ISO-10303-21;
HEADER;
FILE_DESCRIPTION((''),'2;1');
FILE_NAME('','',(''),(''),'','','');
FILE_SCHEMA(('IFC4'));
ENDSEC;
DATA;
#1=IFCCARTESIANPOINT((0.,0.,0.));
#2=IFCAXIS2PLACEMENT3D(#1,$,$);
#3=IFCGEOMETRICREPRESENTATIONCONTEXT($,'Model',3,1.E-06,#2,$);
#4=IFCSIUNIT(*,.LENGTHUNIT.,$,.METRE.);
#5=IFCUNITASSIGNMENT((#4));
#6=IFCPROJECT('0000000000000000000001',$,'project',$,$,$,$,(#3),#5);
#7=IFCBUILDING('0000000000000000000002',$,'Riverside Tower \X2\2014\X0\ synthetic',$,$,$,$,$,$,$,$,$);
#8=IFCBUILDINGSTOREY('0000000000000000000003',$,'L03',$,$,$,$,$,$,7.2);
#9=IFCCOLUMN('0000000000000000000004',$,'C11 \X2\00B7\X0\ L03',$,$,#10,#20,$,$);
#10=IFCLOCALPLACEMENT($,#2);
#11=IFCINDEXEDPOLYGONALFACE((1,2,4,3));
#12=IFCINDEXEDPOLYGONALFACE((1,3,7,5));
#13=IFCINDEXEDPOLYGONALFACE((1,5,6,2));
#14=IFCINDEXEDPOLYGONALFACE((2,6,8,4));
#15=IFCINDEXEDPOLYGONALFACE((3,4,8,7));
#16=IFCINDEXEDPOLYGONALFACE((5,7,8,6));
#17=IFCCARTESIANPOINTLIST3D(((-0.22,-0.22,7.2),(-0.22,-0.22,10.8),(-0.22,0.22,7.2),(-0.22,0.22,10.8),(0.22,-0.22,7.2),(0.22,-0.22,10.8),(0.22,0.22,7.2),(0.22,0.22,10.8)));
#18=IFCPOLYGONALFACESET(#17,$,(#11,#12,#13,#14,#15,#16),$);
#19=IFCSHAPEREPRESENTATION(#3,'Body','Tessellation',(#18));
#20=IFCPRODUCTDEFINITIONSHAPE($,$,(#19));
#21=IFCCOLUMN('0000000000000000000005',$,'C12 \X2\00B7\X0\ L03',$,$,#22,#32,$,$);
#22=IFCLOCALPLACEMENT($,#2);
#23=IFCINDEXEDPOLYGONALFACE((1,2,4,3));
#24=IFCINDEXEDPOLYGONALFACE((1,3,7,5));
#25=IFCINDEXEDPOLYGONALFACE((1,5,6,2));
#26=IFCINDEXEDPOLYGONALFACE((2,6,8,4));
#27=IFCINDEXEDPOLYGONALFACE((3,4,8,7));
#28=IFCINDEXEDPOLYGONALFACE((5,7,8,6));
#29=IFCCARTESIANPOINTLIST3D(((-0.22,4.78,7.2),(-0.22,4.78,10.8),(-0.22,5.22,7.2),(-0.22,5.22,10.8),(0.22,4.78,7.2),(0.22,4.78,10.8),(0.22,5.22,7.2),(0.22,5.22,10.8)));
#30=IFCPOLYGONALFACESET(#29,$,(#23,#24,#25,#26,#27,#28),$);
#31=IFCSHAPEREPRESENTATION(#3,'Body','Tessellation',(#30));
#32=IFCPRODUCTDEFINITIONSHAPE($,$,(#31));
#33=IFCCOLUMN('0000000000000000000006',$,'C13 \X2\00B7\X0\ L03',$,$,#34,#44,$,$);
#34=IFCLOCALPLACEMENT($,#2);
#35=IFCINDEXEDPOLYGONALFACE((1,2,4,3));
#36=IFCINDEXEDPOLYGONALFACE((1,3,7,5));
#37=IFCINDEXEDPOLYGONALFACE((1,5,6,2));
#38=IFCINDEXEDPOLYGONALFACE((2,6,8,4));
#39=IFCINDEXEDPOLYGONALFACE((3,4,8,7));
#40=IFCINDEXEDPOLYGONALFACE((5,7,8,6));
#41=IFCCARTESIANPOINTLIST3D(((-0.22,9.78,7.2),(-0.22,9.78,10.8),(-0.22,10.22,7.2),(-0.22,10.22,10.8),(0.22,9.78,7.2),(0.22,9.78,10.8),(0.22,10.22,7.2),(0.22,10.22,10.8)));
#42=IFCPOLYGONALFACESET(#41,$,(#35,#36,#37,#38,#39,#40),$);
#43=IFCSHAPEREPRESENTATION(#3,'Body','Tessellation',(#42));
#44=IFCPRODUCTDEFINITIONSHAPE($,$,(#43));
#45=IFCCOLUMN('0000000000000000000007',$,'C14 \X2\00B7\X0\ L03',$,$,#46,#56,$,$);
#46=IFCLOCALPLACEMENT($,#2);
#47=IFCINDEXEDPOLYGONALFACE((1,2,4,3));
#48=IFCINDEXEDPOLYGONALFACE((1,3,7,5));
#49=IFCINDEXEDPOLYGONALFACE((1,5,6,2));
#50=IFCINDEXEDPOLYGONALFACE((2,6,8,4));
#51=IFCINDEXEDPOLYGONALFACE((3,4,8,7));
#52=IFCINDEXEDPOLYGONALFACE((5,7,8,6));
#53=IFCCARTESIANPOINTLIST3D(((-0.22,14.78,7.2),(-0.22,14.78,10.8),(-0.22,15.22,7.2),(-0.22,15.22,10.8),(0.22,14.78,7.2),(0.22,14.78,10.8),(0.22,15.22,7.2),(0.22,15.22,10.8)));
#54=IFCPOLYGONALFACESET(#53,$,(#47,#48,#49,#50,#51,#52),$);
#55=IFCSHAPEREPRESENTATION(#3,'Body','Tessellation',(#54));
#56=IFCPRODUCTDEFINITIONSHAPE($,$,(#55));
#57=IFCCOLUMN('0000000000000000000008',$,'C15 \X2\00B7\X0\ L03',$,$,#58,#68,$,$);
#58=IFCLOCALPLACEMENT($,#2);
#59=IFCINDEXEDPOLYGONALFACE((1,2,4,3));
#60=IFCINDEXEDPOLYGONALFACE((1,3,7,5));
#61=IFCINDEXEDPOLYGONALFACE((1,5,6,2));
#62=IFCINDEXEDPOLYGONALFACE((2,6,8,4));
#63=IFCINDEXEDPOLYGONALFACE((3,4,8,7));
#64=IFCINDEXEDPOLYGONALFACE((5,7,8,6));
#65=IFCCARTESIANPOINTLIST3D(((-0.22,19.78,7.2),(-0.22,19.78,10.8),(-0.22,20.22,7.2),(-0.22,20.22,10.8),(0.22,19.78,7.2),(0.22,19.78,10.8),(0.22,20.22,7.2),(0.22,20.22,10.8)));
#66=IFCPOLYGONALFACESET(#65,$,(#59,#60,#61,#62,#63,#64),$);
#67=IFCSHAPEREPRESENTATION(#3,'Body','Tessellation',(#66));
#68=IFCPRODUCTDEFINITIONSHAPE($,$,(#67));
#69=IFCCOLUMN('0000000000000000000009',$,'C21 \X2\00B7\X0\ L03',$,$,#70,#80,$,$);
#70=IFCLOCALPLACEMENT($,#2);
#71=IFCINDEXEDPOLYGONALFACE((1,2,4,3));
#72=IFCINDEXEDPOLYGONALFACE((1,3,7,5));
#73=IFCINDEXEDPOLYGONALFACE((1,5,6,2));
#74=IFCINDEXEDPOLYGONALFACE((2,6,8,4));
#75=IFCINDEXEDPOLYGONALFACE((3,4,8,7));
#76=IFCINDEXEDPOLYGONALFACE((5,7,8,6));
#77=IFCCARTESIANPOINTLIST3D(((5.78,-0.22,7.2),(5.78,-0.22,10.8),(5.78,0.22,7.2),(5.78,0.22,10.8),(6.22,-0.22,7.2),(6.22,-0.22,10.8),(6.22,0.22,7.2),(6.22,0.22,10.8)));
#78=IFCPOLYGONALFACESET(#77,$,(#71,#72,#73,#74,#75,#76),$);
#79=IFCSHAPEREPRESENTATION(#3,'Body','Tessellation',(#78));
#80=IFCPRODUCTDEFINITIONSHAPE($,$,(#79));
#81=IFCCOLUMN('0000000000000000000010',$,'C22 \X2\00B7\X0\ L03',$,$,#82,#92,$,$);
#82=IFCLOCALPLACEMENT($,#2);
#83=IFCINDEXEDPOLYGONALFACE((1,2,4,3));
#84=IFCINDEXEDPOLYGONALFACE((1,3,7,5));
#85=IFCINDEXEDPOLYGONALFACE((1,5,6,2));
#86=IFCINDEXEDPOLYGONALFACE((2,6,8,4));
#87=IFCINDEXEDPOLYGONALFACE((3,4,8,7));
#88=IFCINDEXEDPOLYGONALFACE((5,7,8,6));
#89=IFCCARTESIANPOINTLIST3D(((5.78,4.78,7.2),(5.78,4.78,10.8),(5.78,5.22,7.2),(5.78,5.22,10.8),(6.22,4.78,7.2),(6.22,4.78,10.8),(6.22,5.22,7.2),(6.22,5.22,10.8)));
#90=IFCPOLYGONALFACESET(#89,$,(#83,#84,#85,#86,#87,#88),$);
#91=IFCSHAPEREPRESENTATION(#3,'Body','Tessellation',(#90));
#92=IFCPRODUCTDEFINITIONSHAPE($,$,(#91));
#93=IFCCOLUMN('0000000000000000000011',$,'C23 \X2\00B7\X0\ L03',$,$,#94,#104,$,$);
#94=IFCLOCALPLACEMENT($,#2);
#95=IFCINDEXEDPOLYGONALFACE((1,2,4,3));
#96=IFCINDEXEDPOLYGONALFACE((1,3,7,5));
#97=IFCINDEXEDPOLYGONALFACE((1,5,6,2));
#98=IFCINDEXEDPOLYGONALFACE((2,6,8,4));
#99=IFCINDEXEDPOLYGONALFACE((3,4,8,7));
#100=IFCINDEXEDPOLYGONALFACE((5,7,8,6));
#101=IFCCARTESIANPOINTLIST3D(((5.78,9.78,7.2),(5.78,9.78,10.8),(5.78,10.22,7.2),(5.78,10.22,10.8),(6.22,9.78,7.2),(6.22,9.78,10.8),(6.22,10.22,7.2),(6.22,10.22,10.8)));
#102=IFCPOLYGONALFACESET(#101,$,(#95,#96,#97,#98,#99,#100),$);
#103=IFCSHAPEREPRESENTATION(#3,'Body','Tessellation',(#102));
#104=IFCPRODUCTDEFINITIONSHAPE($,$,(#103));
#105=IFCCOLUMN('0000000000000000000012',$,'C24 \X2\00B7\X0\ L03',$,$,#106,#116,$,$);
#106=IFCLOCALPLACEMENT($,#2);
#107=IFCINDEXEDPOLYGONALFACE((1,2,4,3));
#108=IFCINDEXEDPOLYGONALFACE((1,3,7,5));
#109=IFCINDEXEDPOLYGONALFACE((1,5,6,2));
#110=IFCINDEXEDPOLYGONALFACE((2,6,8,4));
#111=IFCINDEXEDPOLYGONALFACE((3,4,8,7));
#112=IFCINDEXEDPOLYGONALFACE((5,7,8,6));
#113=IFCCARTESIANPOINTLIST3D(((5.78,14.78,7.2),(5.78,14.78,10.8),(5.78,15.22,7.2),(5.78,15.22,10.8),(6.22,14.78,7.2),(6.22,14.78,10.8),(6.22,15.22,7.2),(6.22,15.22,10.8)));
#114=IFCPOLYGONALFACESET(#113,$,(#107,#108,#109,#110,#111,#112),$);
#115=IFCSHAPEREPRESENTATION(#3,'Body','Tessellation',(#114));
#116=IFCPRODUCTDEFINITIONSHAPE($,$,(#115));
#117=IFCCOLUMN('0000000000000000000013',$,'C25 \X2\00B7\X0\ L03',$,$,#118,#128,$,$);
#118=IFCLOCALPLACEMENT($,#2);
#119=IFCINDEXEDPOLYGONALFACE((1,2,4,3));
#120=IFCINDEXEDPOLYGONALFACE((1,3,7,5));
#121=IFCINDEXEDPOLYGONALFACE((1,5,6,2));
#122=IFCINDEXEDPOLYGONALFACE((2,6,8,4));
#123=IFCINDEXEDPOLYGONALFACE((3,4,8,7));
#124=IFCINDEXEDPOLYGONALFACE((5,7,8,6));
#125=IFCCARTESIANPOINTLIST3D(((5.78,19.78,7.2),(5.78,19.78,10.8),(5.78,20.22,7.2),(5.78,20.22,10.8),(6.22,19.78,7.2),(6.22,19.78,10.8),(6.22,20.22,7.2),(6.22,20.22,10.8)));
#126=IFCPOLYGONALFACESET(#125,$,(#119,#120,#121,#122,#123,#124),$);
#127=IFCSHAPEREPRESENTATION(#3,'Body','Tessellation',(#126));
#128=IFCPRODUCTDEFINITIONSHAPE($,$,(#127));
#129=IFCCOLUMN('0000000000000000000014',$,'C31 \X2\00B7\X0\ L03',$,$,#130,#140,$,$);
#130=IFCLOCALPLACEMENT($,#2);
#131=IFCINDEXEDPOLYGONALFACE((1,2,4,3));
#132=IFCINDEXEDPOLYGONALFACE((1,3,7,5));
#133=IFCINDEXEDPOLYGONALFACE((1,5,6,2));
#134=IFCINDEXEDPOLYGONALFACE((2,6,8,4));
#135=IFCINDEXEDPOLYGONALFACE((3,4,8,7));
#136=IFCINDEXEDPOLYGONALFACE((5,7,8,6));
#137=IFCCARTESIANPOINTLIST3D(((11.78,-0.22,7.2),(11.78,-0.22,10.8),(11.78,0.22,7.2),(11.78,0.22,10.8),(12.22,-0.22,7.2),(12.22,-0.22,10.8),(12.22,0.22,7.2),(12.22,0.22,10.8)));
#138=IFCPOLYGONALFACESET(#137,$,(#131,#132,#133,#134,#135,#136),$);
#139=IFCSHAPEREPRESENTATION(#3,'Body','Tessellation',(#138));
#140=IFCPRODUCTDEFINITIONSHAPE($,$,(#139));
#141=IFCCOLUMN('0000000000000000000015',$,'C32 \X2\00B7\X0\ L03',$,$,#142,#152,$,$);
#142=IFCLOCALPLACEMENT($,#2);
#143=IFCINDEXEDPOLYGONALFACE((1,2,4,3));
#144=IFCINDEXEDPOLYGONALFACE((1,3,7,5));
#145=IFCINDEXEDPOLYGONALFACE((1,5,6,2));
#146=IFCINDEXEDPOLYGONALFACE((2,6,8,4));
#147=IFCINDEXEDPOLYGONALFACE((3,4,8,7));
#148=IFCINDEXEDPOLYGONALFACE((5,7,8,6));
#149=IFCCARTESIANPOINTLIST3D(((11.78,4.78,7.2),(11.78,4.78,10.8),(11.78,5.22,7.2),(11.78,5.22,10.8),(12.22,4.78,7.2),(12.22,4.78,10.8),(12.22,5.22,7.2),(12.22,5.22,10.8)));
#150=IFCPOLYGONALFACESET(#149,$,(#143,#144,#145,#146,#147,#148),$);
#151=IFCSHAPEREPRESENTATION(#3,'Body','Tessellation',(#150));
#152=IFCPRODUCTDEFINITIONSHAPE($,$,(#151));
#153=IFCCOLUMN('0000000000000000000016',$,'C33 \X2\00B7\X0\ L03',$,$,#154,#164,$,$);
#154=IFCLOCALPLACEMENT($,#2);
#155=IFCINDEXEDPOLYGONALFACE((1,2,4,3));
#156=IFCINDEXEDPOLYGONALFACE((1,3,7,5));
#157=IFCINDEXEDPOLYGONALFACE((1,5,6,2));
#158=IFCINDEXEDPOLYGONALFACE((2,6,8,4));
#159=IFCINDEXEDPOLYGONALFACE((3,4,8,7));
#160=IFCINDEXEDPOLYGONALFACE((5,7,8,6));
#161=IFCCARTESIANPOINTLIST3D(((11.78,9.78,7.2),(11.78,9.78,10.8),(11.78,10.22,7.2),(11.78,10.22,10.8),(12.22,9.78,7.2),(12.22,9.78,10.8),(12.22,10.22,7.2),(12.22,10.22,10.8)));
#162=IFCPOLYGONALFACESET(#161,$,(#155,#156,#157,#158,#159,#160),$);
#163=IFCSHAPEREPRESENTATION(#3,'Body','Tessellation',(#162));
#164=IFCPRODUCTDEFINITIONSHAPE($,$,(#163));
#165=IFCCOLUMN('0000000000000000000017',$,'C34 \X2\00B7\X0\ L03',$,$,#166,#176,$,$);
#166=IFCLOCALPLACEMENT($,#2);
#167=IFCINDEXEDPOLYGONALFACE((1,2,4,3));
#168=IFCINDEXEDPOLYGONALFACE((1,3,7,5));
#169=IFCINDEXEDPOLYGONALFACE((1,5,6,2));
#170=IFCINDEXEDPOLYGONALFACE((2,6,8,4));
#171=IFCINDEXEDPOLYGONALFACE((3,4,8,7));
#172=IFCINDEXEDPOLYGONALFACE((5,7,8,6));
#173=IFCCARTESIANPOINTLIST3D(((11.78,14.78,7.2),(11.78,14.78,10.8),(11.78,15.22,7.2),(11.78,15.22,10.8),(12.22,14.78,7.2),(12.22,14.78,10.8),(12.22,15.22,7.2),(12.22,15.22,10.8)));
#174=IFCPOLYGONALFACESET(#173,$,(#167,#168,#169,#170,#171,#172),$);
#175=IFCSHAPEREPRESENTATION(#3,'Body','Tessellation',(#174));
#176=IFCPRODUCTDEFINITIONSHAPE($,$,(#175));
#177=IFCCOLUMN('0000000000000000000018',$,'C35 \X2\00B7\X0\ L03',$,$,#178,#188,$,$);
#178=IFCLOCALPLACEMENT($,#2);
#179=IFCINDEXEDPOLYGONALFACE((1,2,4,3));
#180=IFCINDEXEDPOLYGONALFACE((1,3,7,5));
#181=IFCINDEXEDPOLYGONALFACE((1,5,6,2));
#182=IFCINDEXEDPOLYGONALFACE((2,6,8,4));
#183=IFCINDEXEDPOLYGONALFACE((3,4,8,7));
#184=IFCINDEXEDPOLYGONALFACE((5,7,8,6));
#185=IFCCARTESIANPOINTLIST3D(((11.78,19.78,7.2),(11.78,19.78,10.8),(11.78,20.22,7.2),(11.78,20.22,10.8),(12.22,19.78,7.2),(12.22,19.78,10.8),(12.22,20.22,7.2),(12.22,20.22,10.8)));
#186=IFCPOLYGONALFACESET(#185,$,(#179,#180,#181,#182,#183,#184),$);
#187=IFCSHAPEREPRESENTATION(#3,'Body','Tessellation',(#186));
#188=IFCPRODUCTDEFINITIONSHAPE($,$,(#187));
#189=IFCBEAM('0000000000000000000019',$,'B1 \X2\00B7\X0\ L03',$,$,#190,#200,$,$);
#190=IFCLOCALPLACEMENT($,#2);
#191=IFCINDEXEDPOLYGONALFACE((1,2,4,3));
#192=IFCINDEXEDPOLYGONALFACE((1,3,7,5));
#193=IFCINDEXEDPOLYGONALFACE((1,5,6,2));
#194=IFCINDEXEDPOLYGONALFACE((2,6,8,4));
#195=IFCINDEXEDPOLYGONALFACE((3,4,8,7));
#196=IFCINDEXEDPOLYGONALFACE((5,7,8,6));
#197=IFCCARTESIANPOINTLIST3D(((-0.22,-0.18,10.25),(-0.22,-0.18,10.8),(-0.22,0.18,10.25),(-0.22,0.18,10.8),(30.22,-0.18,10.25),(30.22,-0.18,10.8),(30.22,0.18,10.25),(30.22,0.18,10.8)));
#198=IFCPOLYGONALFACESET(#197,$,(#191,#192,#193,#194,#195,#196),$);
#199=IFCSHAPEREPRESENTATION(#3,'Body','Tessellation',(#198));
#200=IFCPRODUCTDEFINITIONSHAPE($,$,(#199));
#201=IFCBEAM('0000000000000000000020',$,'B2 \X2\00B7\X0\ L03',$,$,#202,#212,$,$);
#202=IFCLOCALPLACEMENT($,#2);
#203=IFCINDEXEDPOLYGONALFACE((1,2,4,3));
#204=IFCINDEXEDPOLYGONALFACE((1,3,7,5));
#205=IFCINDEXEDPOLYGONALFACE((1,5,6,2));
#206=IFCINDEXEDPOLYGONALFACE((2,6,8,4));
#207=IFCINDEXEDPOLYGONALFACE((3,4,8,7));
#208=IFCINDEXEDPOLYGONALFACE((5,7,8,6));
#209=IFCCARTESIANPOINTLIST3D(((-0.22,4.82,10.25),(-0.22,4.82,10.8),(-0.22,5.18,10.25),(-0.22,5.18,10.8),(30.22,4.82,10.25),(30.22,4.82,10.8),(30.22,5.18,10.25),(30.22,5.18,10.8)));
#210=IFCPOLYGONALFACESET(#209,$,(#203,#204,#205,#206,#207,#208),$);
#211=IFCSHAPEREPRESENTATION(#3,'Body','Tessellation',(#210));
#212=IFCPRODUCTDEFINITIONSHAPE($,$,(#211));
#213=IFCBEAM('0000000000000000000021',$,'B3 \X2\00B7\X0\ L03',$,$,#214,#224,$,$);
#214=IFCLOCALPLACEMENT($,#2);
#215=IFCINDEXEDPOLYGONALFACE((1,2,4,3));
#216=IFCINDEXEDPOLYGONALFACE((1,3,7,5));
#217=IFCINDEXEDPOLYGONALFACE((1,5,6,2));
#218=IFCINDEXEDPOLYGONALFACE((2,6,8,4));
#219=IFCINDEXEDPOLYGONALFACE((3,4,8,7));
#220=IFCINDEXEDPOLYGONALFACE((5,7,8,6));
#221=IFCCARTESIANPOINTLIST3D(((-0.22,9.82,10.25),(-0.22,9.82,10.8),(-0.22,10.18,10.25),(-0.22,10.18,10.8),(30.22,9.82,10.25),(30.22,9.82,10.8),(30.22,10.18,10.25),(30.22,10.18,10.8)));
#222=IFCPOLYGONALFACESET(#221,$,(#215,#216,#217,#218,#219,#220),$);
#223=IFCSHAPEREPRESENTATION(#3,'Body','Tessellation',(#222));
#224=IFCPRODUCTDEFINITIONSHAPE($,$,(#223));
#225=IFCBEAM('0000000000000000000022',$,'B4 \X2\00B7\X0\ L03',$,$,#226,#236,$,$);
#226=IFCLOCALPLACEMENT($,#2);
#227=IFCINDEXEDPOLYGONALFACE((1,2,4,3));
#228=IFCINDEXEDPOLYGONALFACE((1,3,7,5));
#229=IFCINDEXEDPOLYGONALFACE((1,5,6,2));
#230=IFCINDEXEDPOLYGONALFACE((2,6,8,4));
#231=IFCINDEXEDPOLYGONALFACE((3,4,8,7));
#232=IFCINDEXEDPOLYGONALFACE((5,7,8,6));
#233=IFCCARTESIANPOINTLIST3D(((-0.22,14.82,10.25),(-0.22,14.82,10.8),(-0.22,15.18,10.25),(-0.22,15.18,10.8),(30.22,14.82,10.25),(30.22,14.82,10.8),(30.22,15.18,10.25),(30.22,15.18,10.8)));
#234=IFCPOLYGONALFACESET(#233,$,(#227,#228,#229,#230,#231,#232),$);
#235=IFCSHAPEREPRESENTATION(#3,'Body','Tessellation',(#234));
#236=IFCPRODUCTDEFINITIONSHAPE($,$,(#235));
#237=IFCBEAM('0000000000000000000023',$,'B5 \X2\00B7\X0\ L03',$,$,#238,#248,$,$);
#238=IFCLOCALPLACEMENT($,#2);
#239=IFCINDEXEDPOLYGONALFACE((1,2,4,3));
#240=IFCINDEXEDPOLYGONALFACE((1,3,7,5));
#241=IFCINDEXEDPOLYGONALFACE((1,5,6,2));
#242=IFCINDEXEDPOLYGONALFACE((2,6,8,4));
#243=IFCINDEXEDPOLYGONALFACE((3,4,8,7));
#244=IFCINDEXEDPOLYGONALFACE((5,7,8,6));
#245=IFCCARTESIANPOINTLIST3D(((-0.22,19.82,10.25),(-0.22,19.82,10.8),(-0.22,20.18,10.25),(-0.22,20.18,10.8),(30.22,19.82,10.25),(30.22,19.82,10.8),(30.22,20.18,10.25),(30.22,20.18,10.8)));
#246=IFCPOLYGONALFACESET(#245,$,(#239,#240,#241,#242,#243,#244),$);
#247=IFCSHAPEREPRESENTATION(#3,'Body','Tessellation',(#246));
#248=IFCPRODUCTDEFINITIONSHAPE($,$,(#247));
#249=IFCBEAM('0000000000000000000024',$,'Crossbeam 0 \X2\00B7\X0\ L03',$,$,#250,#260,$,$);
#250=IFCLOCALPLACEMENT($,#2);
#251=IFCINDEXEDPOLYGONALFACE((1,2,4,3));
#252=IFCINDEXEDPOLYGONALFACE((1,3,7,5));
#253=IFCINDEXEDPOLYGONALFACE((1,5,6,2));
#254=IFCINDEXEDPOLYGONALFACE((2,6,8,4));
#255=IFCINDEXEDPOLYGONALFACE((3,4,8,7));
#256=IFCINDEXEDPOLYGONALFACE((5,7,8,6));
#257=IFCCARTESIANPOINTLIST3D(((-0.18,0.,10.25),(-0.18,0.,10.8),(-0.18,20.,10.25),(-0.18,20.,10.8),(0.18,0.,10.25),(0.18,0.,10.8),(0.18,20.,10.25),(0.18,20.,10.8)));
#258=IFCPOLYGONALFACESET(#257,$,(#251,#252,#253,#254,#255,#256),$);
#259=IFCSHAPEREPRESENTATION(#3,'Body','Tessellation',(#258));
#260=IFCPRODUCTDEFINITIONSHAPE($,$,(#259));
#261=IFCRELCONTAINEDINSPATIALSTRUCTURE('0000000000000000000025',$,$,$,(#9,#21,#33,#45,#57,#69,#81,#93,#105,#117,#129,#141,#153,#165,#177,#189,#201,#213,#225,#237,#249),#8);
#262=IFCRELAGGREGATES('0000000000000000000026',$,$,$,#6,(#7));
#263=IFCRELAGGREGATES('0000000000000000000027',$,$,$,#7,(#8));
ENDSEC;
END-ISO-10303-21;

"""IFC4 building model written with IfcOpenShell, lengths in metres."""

from ifc_helpers import new_model, si_unit, frame, origin, place, context, project, spatial, rectangle, extrude, element, save


model = new_model("IFC4")

# Units and contexts
model_context = context("Model", 3, precision=1e-06, world=origin())
ifc_project = project(units=[si_unit("LENGTHUNIT", "METRE")], contexts=[model_context])

# Building, storey
building = spatial("IfcBuilding", under=ifc_project, Name="Riverside Tower — synthetic")
storey = spatial("IfcBuildingStorey", under=building, Name="L03", Elevation=7.2)

# Columns
for number, where, name in (
    (1, (0.0, 0.0, 7.2), "C11 · L03"),
    (2, (0.0, 5.0, 7.2), "C12 · L03"),
    (3, (0.0, 10.0, 7.2), "C13 · L03"),
    (4, (0.0, 15.0, 7.2), "C14 · L03"),
    (5, (0.0, 20.0, 7.2), "C15 · L03"),
    (6, (6.0, 0.0, 7.2), "C21 · L03"),
    (7, (6.0, 5.0, 7.2), "C22 · L03"),
    (8, (6.0, 10.0, 7.2), "C23 · L03"),
    (9, (6.0, 15.0, 7.2), "C24 · L03"),
    (10, (6.0, 20.0, 7.2), "C25 · L03"),
    (11, (12.0, 0.0, 7.2), "C31 · L03"),
    (12, (12.0, 5.0, 7.2), "C32 · L03"),
    (13, (12.0, 10.0, 7.2), "C33 · L03"),
    (14, (12.0, 15.0, 7.2), "C34 · L03"),
    (15, (12.0, 20.0, 7.2), "C35 · L03"),
):
    element("IfcColumn", number, at=place(None, frame(where)), inside=storey, Name=name, context=model_context, shape_type="SweptSolid", body=[
        extrude(rectangle(XDim=0.44, YDim=0.44), origin(), (0.0, 0.0, 1.0), 3.6),
    ])

# Beams
for number, where, name in (
    (16, (15.0, 0.0, 10.25), "B1 · L03"),
    (17, (15.0, 5.0, 10.25), "B2 · L03"),
    (18, (15.0, 10.0, 10.25), "B3 · L03"),
    (19, (15.0, 15.0, 10.25), "B4 · L03"),
    (20, (15.0, 20.0, 10.25), "B5 · L03"),
):
    element("IfcBeam", number, at=place(None, frame(where)), inside=storey, Name=name, context=model_context, shape_type="SweptSolid", body=[
        extrude(rectangle(XDim=30.44, YDim=0.36), origin(), (0.0, 0.0, 1.0), 0.55),
    ])
for number, where, name in (
    (21, (0.0, 10.0, 10.25), "Crossbeam 0 · L03"),
):
    element("IfcBeam", number, at=place(None, frame(where)), inside=storey, Name=name, context=model_context, shape_type="SweptSolid", body=[
        extrude(rectangle(XDim=0.36, YDim=20.0), origin(), (0.0, 0.0, 1.0), 0.55),
    ])

save(model, "model.ifc")
